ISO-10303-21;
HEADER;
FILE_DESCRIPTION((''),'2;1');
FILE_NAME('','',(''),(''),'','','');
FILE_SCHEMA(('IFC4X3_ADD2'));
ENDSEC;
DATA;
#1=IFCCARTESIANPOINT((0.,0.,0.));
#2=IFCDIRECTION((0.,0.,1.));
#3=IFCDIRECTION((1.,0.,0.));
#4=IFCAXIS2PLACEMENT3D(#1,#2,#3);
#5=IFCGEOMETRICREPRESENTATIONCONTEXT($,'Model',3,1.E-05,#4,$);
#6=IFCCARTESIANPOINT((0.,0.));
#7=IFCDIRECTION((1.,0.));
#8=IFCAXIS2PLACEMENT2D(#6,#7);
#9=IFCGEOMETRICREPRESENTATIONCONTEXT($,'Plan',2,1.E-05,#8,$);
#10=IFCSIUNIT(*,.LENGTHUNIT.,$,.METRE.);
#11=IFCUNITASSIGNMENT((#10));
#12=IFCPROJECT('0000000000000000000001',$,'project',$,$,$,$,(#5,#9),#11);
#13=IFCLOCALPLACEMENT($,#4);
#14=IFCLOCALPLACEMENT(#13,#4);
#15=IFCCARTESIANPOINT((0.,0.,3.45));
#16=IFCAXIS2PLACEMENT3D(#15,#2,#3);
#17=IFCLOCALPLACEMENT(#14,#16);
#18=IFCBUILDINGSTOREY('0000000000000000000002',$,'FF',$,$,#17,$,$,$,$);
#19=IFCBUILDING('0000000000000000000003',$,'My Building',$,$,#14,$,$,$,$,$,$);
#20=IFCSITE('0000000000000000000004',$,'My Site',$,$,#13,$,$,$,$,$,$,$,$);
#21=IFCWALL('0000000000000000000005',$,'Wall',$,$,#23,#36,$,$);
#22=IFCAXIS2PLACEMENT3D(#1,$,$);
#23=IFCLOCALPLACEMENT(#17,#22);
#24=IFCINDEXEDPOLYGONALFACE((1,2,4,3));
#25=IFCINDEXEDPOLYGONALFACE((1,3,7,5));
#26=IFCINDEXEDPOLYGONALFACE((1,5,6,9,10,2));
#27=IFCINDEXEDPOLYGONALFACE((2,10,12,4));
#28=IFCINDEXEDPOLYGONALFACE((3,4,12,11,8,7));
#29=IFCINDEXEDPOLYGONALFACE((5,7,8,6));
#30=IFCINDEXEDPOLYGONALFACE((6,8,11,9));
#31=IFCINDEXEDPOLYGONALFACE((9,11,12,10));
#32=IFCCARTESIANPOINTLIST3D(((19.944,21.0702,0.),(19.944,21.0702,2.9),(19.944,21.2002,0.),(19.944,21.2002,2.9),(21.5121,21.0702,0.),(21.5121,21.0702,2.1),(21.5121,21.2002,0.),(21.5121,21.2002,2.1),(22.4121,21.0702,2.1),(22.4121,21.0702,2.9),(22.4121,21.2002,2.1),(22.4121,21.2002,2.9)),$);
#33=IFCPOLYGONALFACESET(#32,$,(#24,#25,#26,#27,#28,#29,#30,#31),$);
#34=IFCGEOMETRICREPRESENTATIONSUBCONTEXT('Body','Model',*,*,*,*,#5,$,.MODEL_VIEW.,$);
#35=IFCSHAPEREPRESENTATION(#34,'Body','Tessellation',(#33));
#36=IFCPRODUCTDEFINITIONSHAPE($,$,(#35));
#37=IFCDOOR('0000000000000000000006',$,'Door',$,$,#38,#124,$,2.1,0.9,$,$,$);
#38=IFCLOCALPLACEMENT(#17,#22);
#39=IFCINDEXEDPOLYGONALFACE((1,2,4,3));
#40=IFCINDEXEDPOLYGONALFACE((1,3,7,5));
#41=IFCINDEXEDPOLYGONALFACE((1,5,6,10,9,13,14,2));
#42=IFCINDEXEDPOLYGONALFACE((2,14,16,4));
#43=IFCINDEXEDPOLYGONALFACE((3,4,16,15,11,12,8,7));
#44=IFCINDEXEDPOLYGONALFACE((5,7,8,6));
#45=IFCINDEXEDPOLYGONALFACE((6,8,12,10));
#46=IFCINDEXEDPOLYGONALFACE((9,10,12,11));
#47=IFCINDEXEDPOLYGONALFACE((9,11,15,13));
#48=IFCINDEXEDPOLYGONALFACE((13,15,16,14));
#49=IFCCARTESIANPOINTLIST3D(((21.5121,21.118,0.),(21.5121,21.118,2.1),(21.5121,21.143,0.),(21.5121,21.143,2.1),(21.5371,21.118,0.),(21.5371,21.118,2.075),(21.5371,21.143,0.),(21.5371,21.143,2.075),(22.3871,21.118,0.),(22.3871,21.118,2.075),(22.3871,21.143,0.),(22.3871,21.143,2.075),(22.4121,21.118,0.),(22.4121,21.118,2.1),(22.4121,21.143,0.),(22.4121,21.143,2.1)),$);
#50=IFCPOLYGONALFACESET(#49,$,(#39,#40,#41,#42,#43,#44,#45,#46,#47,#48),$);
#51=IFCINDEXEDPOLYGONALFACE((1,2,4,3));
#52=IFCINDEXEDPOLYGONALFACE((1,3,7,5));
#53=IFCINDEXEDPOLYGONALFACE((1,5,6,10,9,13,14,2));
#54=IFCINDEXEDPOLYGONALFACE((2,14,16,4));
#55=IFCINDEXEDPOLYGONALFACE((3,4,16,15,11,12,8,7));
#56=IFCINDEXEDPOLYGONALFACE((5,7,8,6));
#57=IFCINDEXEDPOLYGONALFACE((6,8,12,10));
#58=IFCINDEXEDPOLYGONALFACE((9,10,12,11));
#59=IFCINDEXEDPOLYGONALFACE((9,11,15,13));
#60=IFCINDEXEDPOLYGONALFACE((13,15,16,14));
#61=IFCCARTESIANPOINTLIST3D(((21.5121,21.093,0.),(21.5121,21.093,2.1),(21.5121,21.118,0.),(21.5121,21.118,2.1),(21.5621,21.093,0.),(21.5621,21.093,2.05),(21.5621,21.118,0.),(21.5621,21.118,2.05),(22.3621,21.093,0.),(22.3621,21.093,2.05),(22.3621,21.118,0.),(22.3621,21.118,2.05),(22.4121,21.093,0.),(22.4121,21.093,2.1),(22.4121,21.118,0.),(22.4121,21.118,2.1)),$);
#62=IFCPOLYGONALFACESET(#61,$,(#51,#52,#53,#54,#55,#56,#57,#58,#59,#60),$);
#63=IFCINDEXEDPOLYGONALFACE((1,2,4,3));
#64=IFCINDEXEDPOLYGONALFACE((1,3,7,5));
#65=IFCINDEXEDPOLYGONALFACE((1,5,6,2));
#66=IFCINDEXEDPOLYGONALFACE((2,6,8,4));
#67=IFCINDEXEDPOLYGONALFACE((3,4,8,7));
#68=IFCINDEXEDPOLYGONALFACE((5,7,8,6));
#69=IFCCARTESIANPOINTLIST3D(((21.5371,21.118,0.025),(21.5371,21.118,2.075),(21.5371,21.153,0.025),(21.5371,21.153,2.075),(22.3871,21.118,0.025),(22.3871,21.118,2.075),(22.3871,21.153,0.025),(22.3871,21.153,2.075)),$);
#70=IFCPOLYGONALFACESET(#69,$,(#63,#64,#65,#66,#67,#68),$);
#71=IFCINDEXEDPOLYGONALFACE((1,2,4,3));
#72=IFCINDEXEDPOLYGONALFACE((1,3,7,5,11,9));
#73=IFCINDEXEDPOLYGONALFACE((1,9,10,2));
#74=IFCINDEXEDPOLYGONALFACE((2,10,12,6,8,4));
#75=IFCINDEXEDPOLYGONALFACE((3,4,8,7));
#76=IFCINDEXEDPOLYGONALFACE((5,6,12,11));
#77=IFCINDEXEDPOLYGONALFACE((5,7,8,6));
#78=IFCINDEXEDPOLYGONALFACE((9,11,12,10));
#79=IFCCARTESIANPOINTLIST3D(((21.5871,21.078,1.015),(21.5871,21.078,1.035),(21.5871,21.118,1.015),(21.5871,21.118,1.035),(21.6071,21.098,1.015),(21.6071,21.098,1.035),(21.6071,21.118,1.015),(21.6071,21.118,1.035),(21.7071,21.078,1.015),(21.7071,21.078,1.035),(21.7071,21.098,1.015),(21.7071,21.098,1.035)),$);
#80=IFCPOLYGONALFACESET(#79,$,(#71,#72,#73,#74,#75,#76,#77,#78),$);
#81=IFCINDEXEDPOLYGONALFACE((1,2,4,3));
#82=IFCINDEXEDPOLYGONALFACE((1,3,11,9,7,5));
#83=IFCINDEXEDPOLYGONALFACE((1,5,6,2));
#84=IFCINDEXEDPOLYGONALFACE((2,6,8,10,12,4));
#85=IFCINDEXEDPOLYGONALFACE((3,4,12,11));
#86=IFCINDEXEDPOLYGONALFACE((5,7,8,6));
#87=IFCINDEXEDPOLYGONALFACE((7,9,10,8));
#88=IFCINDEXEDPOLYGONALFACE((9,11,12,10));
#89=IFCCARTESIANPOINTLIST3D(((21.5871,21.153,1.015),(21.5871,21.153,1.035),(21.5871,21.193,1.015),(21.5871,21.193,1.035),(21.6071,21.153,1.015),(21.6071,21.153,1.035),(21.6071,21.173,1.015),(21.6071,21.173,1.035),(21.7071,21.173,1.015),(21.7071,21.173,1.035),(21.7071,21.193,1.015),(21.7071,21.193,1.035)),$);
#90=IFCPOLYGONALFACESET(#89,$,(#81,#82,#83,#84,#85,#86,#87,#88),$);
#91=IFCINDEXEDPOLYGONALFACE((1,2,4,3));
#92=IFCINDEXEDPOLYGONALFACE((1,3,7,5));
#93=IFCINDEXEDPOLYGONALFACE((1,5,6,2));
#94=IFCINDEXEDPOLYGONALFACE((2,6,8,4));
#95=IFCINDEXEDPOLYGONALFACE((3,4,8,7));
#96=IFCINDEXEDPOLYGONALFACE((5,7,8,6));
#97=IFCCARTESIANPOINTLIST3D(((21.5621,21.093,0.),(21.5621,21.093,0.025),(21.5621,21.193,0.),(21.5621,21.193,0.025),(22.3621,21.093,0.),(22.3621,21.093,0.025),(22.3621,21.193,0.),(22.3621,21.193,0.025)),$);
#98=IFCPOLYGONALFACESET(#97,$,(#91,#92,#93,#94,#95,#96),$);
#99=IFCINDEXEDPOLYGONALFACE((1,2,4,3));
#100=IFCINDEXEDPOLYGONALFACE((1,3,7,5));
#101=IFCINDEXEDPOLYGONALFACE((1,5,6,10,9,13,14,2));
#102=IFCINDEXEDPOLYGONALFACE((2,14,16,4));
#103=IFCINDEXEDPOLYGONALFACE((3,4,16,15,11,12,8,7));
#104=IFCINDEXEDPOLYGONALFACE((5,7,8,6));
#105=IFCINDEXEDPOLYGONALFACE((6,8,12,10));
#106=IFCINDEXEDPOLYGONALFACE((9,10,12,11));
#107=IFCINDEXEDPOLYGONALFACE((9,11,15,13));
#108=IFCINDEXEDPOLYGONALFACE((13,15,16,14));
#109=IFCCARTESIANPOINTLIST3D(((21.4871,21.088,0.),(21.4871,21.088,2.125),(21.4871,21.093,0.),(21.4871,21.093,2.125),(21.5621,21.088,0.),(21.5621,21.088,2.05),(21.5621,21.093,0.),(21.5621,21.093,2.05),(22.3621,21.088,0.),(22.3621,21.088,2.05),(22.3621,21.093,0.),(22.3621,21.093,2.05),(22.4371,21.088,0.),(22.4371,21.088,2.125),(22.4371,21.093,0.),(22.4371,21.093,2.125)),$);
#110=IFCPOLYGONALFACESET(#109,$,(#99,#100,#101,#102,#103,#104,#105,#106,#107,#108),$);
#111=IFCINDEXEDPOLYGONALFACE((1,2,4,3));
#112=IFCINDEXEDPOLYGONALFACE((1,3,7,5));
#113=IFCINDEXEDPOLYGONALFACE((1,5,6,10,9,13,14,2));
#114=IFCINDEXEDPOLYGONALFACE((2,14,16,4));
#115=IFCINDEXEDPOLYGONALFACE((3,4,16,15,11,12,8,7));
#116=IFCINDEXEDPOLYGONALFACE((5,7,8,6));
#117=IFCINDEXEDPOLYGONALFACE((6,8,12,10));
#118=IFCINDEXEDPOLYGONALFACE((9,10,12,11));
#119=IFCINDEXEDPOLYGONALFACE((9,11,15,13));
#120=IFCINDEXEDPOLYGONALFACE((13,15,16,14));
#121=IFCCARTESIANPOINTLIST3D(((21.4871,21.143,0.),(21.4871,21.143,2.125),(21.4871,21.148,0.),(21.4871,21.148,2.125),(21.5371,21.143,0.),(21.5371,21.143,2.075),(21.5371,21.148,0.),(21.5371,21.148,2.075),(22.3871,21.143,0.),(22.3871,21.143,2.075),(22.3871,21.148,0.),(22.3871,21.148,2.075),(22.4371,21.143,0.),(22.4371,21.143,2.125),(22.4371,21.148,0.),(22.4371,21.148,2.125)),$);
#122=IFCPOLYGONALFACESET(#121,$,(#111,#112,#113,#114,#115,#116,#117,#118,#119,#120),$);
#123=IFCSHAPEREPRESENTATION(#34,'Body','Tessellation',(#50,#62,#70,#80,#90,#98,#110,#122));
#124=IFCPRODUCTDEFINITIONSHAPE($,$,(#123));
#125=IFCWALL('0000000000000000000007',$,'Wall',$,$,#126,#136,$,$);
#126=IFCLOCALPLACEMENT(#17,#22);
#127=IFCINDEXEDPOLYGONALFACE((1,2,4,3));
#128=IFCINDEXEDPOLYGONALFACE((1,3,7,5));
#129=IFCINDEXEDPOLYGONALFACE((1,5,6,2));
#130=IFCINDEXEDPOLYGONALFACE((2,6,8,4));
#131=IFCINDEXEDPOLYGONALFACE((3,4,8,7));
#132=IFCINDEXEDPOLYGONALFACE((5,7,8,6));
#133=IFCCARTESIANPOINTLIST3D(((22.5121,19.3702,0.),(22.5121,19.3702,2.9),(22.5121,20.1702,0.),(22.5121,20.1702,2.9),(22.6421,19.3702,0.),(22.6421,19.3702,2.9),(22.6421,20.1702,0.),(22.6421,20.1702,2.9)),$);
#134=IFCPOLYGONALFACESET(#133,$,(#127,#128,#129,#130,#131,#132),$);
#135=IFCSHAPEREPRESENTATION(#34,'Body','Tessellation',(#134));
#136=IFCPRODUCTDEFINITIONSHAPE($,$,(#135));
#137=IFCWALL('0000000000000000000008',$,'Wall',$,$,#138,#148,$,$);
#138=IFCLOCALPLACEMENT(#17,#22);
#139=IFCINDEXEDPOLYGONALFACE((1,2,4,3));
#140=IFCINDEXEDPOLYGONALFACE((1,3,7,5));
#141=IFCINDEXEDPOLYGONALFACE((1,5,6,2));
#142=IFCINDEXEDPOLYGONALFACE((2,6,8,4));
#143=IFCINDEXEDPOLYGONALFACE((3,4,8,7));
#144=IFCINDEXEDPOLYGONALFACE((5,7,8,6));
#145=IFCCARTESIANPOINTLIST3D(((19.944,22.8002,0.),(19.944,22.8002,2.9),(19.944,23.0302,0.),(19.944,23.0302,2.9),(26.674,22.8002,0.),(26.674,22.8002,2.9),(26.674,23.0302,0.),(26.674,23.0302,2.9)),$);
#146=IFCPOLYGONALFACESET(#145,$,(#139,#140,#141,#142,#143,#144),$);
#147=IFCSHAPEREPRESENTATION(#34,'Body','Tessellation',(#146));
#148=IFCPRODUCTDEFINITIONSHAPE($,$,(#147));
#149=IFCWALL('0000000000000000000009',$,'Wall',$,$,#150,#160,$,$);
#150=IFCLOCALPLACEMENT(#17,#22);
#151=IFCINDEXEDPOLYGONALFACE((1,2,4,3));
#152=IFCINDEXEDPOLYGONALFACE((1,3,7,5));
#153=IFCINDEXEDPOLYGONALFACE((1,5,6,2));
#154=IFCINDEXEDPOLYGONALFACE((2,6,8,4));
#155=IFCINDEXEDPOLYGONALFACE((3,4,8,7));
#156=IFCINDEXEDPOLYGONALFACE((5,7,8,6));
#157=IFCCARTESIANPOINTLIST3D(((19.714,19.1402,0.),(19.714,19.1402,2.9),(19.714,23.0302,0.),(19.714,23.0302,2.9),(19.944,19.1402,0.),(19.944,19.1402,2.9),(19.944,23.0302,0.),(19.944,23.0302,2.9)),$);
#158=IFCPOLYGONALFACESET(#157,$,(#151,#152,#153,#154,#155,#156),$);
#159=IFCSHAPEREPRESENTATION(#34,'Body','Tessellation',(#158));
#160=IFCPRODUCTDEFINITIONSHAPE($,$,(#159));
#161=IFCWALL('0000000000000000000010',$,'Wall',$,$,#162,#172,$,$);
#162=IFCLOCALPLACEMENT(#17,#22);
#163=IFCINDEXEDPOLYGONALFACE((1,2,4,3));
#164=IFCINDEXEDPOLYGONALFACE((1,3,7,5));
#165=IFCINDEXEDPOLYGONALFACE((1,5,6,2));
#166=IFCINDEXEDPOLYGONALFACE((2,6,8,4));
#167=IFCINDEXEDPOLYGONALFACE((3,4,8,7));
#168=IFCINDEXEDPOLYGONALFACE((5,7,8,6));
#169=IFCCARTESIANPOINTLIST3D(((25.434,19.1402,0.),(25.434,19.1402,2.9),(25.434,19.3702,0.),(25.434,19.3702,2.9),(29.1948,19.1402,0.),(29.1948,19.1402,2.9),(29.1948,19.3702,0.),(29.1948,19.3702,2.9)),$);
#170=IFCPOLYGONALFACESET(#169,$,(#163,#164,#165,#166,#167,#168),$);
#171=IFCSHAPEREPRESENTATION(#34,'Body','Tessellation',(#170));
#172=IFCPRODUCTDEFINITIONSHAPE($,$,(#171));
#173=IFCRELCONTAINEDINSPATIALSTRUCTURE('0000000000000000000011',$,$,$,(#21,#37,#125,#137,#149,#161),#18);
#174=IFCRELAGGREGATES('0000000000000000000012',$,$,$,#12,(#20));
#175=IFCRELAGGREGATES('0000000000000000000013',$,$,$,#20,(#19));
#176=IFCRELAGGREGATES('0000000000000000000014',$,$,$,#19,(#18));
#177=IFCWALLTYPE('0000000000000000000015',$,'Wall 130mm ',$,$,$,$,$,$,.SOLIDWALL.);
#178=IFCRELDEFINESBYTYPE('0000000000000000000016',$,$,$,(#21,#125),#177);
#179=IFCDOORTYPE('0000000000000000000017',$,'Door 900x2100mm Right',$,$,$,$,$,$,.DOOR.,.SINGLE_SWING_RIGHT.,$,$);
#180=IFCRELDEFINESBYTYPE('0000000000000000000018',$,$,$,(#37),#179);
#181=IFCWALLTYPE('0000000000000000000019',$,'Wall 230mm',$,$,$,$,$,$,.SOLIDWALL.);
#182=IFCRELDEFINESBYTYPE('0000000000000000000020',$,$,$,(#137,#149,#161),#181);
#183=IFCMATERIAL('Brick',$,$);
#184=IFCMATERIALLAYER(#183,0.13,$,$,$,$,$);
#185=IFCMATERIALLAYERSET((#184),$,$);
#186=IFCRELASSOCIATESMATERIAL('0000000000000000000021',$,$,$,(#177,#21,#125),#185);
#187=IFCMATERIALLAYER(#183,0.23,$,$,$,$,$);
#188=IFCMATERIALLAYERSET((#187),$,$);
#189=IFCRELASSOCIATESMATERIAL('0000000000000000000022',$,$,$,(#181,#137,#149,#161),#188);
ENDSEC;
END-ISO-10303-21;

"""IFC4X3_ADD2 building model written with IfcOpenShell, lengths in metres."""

from ifc_helpers import new_model, entity, si_unit, frame, origin_with_axes, origin_2d_with_axis, place, context, subcontext, project, spatial, line, indexed_curve, outline, extrude, shape, source, transform, mapped, material, layer, layer_set, layer_usage, type_object, type_shapes, element, fill, save


model = new_model("IFC4X3_ADD2")

# Units and contexts
model_context = context("Model", 3, precision=1e-05, world=origin_with_axes())
plan_context = context("Plan", 2, precision=1e-05, world=origin_2d_with_axis())
body_context_1 = subcontext(model_context, "Body", "Model", "MODEL_VIEW")
body_context_2 = subcontext(plan_context, "Body", "Plan", "PLAN_VIEW")
ifc_project = project(units=[si_unit("LENGTHUNIT", "METRE")], contexts=[model_context, plan_context])

# Site, building, storey
site_placement = place(None, origin_with_axes())
site = spatial("IfcSite", under=ifc_project, at=site_placement, Name="My Site")
building_placement = place(site_placement, origin_with_axes())
building = spatial("IfcBuilding", under=site, at=building_placement, Name="My Building")
storey_placement = place(building_placement, frame((0.0, 0.0, 3.45), z_axis=(0.0, 0.0, 1.0), x_axis=(1.0, 0.0, 0.0)))
storey = spatial("IfcBuildingStorey", under=building, at=storey_placement, Name="FF")

# Wall, opening, door
ifc_material = material(Name="Brick")
ifc_layer_1 = layer(ifc_material, 0.13)
ifc_layer_set_1 = layer_set([ifc_layer_1])
ifc_layer_usage_1 = layer_usage(ifc_layer_set_1, "AXIS2", "POSITIVE", 0.0)
wall_type_1 = type_object("IfcWallType", Name="Wall 130mm ", PredefinedType="SOLIDWALL", material=ifc_layer_set_1)
wall_1_placement = place(storey_placement, frame((22.4121, 21.2002, 0.0), z_axis=(0.0, 0.0, 1.0), x_axis=(-1.0, 0.0, 0.0)))
wall_1 = element("IfcWall", 1, at=wall_1_placement, inside=storey, type_object=wall_type_1, material=ifc_layer_usage_1, Name="Wall", context=body_context_1, shape_type="SweptSolid", body=[
    extrude(outline(indexed_curve([(0.0, 0.0), (0.0, 0.13), (2.4681, 0.13), (2.4681, 0.0), (0.0, 0.0)], self_intersect=False)), origin_with_axes(), (0.0, 0.0, 1.0), 2.9),
])
shared_shape_1 = source(origin_with_axes(), body_context_1, "Body", "SweptSolid", [
    extrude(outline(indexed_curve([(0.0, 0.0), (0.9, 0.0), (0.9, 2.1), (0.0, 2.1)], segments=[line(1, 2, 3, 4, 1)])), frame((0.0, -0.6, 0.0), z_axis=(0.0, -1.0, 0.0), x_axis=(1.0, 0.0, 0.0)), (0.0, 0.0, -1.0), 1.2),
])
opening_placement = place(wall_1_placement, frame((0.9, 0.1072, 0.0), z_axis=(0.0, 0.0, 1.0), x_axis=(-1.0, 0.0, 0.0)))
opening = element("IfcOpeningElement", 2, at=opening_placement, cuts=wall_1, PredefinedType="OPENING", context=body_context_1, shape_type="MappedRepresentation", body=[
    mapped(shared_shape_1, transform((0.0, 0.0, 0.0), x_axis=(1.0, 0.0, 0.0), y_axis=(0.0, 1.0, 0.0), z_axis=(0.0, 0.0, 1.0), scale=1.0)),
])
door_type = type_object("IfcDoorType", Name="Door 900x2100mm Right", OperationType="SINGLE_SWING_RIGHT", PredefinedType="DOOR")
shared_shape_2 = source(origin_with_axes(), body_context_1, "Body", "SweptSolid", [
    extrude(outline(indexed_curve([(0.0, 0.0), (0.0, 2.1), (0.9, 2.1), (0.9, 0.0), (0.875, 0.0), (0.875, 2.075), (0.025, 2.075), (0.025, 0.0)], segments=[line(1, 2, 3, 4, 5, 6, 7, 8, 1)])), frame((0.0, 0.025, 0.0), z_axis=(0.0, -1.0, 0.0), x_axis=(1.0, 0.0, 0.0)), (0.0, 0.0, -1.0), 0.025),
    extrude(outline(indexed_curve([(0.0, 0.0), (0.0, 2.1), (0.9, 2.1), (0.9, 0.0), (0.85, 0.0), (0.85, 2.05), (0.05, 2.05), (0.05, 0.0)], segments=[line(1, 2, 3, 4, 5, 6, 7, 8, 1)])), frame((0.0, 0.0, 0.0), z_axis=(0.0, -1.0, 0.0), x_axis=(1.0, 0.0, 0.0)), (0.0, 0.0, -1.0), 0.025),
    extrude(outline(indexed_curve([(0.0, 0.0), (0.85, 0.0), (0.85, 0.035), (0.0, 0.035)], segments=[line(1, 2, 3, 4, 1)])), frame((0.025, 0.025, 0.025), z_axis=(0.0, 0.0, 1.0), x_axis=(1.0, 0.0, 0.0)), (0.0, 0.0, 1.0), 2.05),
    extrude(outline(indexed_curve([(0.0, 0.0), (0.0, -0.04), (0.12, -0.04), (0.12, -0.02), (0.02, -0.02), (0.02, 0.0)], segments=[line(1, 2, 3, 4, 5, 6, 1)])), frame((0.075, 0.025, 1.015), z_axis=(0.0, 0.0, 1.0), x_axis=(1.0, 0.0, 0.0)), (0.0, 0.0, 1.0), 0.02),
    extrude(outline(indexed_curve([(0.0, 0.0), (0.0, 0.04), (0.12, 0.04), (0.12, 0.02), (0.02, 0.02), (0.02, 0.0)], segments=[line(1, 2, 3, 4, 5, 6, 1)])), frame((0.075, 0.06, 1.015), z_axis=(0.0, 0.0, 1.0), x_axis=(1.0, 0.0, 0.0)), (0.0, 0.0, 1.0), 0.02),
    extrude(outline(indexed_curve([(0.0, 0.0), (0.8, 0.0), (0.8, 0.1), (0.0, 0.1)], segments=[line(1, 2, 3, 4, 1)])), frame((0.05, 0.0, 0.0), z_axis=(0.0, 0.0, 1.0), x_axis=(1.0, 0.0, 0.0)), (0.0, 0.0, 1.0), 0.025),
    extrude(outline(indexed_curve([(0.0, 0.0), (0.0, 2.125), (0.95, 2.125), (0.95, 0.0), (0.875, 0.0), (0.875, 2.05), (0.075, 2.05), (0.075, 0.0)], segments=[line(1, 2, 3, 4, 5, 6, 7, 8, 1)])), frame((-0.025, -0.005, 0.0), z_axis=(0.0, -1.0, 0.0), x_axis=(1.0, 0.0, 0.0)), (0.0, 0.0, -1.0), 0.005),
    extrude(outline(indexed_curve([(0.0, 0.0), (0.0, 2.125), (0.95, 2.125), (0.95, 0.0), (0.9, 0.0), (0.9, 2.075), (0.05, 2.075), (0.05, 0.0)], segments=[line(1, 2, 3, 4, 5, 6, 7, 8, 1)])), frame((-0.025, 0.05, 0.0), z_axis=(0.0, -1.0, 0.0), x_axis=(1.0, 0.0, 0.0)), (0.0, 0.0, -1.0), 0.005),
])
shared_shape_3 = source(origin_with_axes(), body_context_2, "Body", "Curve2D", [
    entity("IfcIndexedPolyCurve", entity("IfcCartesianPointList2D", [[0.0, 0.0], [0.0, 0.05], [0.025, 0.05], [0.025, 0.025], [0.05, 0.025], [0.05, 0.0]]), [entity("IfcLineIndex", [1, 2, 3, 4, 5, 6, 1])]),
    entity("IfcIndexedPolyCurve", entity("IfcCartesianPointList2D", [[0.9, 0.0], [0.9, 0.05], [0.875, 0.05], [0.875, 0.025], [0.85, 0.025], [0.85, 0.0]]), [entity("IfcLineIndex", [1, 2, 3, 4, 5, 6, 1])]),
    entity("IfcTrimmedCurve", entity("IfcEllipse", entity("IfcAxis2Placement2D", entity("IfcCartesianPoint", [0.84, 0.05]), entity("IfcDirection", [1.0, 0.0])), 0.815, 0.85), [entity("IfcCartesianPoint", [0.84, 0.9])], [entity("IfcCartesianPoint", [0.025, 0.05])], True, "CARTESIAN"),
    entity("IfcIndexedPolyCurve", entity("IfcCartesianPointList2D", [[0.875, 0.05], [0.84, 0.05], [0.84, 0.9], [0.875, 0.9]]), [entity("IfcLineIndex", [1, 2, 3, 4, 1])]),
])
type_shapes(door_type, [shared_shape_2, shared_shape_3])
door_placement = place(opening_placement, frame((0.0, 0.0, 0.0), z_axis=(0.0, 0.0, 1.0), x_axis=(1.0, 0.0, 0.0)))
door = element("IfcDoor", 3, at=door_placement, inside=storey, type_object=door_type, Name="Door", OverallHeight=2.1, OverallWidth=0.9, shapes=[
    shape(body_context_1, "Body", "MappedRepresentation", [mapped(shared_shape_2, transform((0.0, 0.0, 0.0), x_axis=(1.0, 0.0, 0.0), y_axis=(0.0, 1.0, 0.0), z_axis=(0.0, 0.0, 1.0), scale=1.0))]),
    shape(body_context_2, "Body", "MappedRepresentation", [mapped(shared_shape_3, transform((0.0, 0.0, 0.0), x_axis=(1.0, 0.0, 0.0), y_axis=(0.0, 1.0, 0.0), z_axis=(0.0, 0.0, 1.0), scale=1.0))]),
])
fill(opening, door)

# Walls
ifc_layer_usage_2 = layer_usage(ifc_layer_set_1, "AXIS2", "POSITIVE", 0.0)
wall_2_placement = place(storey_placement, frame((22.6421, 19.3702, 0.0), z_axis=(0.0, 0.0, 1.0), x_axis=(0.000001, 1.0, 0.0)))
element("IfcWall", 4, at=wall_2_placement, inside=storey, type_object=wall_type_1, material=ifc_layer_usage_2, Name="Wall", context=body_context_1, shape_type="SweptSolid", body=[
    extrude(outline(indexed_curve([(0.0, 0.0), (0.0, 0.13), (0.8, 0.13), (0.8, 0.0), (0.0, 0.0)], self_intersect=False)), origin_with_axes(), (0.0, 0.0, 1.0), 2.9),
])
ifc_layer_2 = layer(ifc_material, 0.23)
ifc_layer_set_2 = layer_set([ifc_layer_2])
ifc_layer_usage_3 = layer_usage(ifc_layer_set_2, "AXIS2", "POSITIVE", 0.0)
wall_type_2 = type_object("IfcWallType", Name="Wall 230mm", PredefinedType="SOLIDWALL", material=ifc_layer_set_2)
wall_3_placement = place(storey_placement, frame((26.674, 23.0302, 0.0), z_axis=(0.0, 0.0, 1.0), x_axis=(-1.0, 0.0, 0.0)))
element("IfcWall", 5, at=wall_3_placement, inside=storey, type_object=wall_type_2, material=ifc_layer_usage_3, Name="Wall", context=body_context_1, shape_type="SweptSolid", body=[
    extrude(outline(indexed_curve([(0.0, 0.0), (0.0, 0.23), (6.73, 0.23), (6.73, 0.0), (0.0, 0.0)], self_intersect=False)), origin_with_axes(), (0.0, 0.0, 1.0), 2.9),
])
ifc_layer_usage_4 = layer_usage(ifc_layer_set_2, "AXIS2", "POSITIVE", 0.0)
wall_4_placement = place(storey_placement, frame((19.944, 19.1402, 0.0), z_axis=(0.0, 0.0, 1.0), x_axis=(0.000001, 1.0, 0.0)))
element("IfcWall", 6, at=wall_4_placement, inside=storey, type_object=wall_type_2, material=ifc_layer_usage_4, Name="Wall", context=body_context_1, shape_type="SweptSolid", body=[
    extrude(outline(indexed_curve([(0.0, 0.0), (0.0, 0.23), (3.89, 0.23), (3.89, 0.0), (0.0, 0.0)], self_intersect=False)), origin_with_axes(), (0.0, 0.0, 1.0), 2.9),
])
ifc_layer_usage_5 = layer_usage(ifc_layer_set_2, "AXIS2", "POSITIVE", 0.0)
wall_5_placement = place(storey_placement, frame((29.1948, 19.3702, 0.0), z_axis=(0.0, 0.0, 1.0), x_axis=(-1.0, 0.0, 0.0)))
element("IfcWall", 7, at=wall_5_placement, inside=storey, type_object=wall_type_2, material=ifc_layer_usage_5, Name="Wall", context=body_context_1, shape_type="SweptSolid", body=[
    extrude(outline(indexed_curve([(0.0, 0.0), (0.0, 0.23), (3.7608, 0.23), (3.7608, 0.0), (0.0, 0.0)], self_intersect=False)), origin_with_axes(), (0.0, 0.0, 1.0), 2.9),
])

save(model, "model.ifc")
